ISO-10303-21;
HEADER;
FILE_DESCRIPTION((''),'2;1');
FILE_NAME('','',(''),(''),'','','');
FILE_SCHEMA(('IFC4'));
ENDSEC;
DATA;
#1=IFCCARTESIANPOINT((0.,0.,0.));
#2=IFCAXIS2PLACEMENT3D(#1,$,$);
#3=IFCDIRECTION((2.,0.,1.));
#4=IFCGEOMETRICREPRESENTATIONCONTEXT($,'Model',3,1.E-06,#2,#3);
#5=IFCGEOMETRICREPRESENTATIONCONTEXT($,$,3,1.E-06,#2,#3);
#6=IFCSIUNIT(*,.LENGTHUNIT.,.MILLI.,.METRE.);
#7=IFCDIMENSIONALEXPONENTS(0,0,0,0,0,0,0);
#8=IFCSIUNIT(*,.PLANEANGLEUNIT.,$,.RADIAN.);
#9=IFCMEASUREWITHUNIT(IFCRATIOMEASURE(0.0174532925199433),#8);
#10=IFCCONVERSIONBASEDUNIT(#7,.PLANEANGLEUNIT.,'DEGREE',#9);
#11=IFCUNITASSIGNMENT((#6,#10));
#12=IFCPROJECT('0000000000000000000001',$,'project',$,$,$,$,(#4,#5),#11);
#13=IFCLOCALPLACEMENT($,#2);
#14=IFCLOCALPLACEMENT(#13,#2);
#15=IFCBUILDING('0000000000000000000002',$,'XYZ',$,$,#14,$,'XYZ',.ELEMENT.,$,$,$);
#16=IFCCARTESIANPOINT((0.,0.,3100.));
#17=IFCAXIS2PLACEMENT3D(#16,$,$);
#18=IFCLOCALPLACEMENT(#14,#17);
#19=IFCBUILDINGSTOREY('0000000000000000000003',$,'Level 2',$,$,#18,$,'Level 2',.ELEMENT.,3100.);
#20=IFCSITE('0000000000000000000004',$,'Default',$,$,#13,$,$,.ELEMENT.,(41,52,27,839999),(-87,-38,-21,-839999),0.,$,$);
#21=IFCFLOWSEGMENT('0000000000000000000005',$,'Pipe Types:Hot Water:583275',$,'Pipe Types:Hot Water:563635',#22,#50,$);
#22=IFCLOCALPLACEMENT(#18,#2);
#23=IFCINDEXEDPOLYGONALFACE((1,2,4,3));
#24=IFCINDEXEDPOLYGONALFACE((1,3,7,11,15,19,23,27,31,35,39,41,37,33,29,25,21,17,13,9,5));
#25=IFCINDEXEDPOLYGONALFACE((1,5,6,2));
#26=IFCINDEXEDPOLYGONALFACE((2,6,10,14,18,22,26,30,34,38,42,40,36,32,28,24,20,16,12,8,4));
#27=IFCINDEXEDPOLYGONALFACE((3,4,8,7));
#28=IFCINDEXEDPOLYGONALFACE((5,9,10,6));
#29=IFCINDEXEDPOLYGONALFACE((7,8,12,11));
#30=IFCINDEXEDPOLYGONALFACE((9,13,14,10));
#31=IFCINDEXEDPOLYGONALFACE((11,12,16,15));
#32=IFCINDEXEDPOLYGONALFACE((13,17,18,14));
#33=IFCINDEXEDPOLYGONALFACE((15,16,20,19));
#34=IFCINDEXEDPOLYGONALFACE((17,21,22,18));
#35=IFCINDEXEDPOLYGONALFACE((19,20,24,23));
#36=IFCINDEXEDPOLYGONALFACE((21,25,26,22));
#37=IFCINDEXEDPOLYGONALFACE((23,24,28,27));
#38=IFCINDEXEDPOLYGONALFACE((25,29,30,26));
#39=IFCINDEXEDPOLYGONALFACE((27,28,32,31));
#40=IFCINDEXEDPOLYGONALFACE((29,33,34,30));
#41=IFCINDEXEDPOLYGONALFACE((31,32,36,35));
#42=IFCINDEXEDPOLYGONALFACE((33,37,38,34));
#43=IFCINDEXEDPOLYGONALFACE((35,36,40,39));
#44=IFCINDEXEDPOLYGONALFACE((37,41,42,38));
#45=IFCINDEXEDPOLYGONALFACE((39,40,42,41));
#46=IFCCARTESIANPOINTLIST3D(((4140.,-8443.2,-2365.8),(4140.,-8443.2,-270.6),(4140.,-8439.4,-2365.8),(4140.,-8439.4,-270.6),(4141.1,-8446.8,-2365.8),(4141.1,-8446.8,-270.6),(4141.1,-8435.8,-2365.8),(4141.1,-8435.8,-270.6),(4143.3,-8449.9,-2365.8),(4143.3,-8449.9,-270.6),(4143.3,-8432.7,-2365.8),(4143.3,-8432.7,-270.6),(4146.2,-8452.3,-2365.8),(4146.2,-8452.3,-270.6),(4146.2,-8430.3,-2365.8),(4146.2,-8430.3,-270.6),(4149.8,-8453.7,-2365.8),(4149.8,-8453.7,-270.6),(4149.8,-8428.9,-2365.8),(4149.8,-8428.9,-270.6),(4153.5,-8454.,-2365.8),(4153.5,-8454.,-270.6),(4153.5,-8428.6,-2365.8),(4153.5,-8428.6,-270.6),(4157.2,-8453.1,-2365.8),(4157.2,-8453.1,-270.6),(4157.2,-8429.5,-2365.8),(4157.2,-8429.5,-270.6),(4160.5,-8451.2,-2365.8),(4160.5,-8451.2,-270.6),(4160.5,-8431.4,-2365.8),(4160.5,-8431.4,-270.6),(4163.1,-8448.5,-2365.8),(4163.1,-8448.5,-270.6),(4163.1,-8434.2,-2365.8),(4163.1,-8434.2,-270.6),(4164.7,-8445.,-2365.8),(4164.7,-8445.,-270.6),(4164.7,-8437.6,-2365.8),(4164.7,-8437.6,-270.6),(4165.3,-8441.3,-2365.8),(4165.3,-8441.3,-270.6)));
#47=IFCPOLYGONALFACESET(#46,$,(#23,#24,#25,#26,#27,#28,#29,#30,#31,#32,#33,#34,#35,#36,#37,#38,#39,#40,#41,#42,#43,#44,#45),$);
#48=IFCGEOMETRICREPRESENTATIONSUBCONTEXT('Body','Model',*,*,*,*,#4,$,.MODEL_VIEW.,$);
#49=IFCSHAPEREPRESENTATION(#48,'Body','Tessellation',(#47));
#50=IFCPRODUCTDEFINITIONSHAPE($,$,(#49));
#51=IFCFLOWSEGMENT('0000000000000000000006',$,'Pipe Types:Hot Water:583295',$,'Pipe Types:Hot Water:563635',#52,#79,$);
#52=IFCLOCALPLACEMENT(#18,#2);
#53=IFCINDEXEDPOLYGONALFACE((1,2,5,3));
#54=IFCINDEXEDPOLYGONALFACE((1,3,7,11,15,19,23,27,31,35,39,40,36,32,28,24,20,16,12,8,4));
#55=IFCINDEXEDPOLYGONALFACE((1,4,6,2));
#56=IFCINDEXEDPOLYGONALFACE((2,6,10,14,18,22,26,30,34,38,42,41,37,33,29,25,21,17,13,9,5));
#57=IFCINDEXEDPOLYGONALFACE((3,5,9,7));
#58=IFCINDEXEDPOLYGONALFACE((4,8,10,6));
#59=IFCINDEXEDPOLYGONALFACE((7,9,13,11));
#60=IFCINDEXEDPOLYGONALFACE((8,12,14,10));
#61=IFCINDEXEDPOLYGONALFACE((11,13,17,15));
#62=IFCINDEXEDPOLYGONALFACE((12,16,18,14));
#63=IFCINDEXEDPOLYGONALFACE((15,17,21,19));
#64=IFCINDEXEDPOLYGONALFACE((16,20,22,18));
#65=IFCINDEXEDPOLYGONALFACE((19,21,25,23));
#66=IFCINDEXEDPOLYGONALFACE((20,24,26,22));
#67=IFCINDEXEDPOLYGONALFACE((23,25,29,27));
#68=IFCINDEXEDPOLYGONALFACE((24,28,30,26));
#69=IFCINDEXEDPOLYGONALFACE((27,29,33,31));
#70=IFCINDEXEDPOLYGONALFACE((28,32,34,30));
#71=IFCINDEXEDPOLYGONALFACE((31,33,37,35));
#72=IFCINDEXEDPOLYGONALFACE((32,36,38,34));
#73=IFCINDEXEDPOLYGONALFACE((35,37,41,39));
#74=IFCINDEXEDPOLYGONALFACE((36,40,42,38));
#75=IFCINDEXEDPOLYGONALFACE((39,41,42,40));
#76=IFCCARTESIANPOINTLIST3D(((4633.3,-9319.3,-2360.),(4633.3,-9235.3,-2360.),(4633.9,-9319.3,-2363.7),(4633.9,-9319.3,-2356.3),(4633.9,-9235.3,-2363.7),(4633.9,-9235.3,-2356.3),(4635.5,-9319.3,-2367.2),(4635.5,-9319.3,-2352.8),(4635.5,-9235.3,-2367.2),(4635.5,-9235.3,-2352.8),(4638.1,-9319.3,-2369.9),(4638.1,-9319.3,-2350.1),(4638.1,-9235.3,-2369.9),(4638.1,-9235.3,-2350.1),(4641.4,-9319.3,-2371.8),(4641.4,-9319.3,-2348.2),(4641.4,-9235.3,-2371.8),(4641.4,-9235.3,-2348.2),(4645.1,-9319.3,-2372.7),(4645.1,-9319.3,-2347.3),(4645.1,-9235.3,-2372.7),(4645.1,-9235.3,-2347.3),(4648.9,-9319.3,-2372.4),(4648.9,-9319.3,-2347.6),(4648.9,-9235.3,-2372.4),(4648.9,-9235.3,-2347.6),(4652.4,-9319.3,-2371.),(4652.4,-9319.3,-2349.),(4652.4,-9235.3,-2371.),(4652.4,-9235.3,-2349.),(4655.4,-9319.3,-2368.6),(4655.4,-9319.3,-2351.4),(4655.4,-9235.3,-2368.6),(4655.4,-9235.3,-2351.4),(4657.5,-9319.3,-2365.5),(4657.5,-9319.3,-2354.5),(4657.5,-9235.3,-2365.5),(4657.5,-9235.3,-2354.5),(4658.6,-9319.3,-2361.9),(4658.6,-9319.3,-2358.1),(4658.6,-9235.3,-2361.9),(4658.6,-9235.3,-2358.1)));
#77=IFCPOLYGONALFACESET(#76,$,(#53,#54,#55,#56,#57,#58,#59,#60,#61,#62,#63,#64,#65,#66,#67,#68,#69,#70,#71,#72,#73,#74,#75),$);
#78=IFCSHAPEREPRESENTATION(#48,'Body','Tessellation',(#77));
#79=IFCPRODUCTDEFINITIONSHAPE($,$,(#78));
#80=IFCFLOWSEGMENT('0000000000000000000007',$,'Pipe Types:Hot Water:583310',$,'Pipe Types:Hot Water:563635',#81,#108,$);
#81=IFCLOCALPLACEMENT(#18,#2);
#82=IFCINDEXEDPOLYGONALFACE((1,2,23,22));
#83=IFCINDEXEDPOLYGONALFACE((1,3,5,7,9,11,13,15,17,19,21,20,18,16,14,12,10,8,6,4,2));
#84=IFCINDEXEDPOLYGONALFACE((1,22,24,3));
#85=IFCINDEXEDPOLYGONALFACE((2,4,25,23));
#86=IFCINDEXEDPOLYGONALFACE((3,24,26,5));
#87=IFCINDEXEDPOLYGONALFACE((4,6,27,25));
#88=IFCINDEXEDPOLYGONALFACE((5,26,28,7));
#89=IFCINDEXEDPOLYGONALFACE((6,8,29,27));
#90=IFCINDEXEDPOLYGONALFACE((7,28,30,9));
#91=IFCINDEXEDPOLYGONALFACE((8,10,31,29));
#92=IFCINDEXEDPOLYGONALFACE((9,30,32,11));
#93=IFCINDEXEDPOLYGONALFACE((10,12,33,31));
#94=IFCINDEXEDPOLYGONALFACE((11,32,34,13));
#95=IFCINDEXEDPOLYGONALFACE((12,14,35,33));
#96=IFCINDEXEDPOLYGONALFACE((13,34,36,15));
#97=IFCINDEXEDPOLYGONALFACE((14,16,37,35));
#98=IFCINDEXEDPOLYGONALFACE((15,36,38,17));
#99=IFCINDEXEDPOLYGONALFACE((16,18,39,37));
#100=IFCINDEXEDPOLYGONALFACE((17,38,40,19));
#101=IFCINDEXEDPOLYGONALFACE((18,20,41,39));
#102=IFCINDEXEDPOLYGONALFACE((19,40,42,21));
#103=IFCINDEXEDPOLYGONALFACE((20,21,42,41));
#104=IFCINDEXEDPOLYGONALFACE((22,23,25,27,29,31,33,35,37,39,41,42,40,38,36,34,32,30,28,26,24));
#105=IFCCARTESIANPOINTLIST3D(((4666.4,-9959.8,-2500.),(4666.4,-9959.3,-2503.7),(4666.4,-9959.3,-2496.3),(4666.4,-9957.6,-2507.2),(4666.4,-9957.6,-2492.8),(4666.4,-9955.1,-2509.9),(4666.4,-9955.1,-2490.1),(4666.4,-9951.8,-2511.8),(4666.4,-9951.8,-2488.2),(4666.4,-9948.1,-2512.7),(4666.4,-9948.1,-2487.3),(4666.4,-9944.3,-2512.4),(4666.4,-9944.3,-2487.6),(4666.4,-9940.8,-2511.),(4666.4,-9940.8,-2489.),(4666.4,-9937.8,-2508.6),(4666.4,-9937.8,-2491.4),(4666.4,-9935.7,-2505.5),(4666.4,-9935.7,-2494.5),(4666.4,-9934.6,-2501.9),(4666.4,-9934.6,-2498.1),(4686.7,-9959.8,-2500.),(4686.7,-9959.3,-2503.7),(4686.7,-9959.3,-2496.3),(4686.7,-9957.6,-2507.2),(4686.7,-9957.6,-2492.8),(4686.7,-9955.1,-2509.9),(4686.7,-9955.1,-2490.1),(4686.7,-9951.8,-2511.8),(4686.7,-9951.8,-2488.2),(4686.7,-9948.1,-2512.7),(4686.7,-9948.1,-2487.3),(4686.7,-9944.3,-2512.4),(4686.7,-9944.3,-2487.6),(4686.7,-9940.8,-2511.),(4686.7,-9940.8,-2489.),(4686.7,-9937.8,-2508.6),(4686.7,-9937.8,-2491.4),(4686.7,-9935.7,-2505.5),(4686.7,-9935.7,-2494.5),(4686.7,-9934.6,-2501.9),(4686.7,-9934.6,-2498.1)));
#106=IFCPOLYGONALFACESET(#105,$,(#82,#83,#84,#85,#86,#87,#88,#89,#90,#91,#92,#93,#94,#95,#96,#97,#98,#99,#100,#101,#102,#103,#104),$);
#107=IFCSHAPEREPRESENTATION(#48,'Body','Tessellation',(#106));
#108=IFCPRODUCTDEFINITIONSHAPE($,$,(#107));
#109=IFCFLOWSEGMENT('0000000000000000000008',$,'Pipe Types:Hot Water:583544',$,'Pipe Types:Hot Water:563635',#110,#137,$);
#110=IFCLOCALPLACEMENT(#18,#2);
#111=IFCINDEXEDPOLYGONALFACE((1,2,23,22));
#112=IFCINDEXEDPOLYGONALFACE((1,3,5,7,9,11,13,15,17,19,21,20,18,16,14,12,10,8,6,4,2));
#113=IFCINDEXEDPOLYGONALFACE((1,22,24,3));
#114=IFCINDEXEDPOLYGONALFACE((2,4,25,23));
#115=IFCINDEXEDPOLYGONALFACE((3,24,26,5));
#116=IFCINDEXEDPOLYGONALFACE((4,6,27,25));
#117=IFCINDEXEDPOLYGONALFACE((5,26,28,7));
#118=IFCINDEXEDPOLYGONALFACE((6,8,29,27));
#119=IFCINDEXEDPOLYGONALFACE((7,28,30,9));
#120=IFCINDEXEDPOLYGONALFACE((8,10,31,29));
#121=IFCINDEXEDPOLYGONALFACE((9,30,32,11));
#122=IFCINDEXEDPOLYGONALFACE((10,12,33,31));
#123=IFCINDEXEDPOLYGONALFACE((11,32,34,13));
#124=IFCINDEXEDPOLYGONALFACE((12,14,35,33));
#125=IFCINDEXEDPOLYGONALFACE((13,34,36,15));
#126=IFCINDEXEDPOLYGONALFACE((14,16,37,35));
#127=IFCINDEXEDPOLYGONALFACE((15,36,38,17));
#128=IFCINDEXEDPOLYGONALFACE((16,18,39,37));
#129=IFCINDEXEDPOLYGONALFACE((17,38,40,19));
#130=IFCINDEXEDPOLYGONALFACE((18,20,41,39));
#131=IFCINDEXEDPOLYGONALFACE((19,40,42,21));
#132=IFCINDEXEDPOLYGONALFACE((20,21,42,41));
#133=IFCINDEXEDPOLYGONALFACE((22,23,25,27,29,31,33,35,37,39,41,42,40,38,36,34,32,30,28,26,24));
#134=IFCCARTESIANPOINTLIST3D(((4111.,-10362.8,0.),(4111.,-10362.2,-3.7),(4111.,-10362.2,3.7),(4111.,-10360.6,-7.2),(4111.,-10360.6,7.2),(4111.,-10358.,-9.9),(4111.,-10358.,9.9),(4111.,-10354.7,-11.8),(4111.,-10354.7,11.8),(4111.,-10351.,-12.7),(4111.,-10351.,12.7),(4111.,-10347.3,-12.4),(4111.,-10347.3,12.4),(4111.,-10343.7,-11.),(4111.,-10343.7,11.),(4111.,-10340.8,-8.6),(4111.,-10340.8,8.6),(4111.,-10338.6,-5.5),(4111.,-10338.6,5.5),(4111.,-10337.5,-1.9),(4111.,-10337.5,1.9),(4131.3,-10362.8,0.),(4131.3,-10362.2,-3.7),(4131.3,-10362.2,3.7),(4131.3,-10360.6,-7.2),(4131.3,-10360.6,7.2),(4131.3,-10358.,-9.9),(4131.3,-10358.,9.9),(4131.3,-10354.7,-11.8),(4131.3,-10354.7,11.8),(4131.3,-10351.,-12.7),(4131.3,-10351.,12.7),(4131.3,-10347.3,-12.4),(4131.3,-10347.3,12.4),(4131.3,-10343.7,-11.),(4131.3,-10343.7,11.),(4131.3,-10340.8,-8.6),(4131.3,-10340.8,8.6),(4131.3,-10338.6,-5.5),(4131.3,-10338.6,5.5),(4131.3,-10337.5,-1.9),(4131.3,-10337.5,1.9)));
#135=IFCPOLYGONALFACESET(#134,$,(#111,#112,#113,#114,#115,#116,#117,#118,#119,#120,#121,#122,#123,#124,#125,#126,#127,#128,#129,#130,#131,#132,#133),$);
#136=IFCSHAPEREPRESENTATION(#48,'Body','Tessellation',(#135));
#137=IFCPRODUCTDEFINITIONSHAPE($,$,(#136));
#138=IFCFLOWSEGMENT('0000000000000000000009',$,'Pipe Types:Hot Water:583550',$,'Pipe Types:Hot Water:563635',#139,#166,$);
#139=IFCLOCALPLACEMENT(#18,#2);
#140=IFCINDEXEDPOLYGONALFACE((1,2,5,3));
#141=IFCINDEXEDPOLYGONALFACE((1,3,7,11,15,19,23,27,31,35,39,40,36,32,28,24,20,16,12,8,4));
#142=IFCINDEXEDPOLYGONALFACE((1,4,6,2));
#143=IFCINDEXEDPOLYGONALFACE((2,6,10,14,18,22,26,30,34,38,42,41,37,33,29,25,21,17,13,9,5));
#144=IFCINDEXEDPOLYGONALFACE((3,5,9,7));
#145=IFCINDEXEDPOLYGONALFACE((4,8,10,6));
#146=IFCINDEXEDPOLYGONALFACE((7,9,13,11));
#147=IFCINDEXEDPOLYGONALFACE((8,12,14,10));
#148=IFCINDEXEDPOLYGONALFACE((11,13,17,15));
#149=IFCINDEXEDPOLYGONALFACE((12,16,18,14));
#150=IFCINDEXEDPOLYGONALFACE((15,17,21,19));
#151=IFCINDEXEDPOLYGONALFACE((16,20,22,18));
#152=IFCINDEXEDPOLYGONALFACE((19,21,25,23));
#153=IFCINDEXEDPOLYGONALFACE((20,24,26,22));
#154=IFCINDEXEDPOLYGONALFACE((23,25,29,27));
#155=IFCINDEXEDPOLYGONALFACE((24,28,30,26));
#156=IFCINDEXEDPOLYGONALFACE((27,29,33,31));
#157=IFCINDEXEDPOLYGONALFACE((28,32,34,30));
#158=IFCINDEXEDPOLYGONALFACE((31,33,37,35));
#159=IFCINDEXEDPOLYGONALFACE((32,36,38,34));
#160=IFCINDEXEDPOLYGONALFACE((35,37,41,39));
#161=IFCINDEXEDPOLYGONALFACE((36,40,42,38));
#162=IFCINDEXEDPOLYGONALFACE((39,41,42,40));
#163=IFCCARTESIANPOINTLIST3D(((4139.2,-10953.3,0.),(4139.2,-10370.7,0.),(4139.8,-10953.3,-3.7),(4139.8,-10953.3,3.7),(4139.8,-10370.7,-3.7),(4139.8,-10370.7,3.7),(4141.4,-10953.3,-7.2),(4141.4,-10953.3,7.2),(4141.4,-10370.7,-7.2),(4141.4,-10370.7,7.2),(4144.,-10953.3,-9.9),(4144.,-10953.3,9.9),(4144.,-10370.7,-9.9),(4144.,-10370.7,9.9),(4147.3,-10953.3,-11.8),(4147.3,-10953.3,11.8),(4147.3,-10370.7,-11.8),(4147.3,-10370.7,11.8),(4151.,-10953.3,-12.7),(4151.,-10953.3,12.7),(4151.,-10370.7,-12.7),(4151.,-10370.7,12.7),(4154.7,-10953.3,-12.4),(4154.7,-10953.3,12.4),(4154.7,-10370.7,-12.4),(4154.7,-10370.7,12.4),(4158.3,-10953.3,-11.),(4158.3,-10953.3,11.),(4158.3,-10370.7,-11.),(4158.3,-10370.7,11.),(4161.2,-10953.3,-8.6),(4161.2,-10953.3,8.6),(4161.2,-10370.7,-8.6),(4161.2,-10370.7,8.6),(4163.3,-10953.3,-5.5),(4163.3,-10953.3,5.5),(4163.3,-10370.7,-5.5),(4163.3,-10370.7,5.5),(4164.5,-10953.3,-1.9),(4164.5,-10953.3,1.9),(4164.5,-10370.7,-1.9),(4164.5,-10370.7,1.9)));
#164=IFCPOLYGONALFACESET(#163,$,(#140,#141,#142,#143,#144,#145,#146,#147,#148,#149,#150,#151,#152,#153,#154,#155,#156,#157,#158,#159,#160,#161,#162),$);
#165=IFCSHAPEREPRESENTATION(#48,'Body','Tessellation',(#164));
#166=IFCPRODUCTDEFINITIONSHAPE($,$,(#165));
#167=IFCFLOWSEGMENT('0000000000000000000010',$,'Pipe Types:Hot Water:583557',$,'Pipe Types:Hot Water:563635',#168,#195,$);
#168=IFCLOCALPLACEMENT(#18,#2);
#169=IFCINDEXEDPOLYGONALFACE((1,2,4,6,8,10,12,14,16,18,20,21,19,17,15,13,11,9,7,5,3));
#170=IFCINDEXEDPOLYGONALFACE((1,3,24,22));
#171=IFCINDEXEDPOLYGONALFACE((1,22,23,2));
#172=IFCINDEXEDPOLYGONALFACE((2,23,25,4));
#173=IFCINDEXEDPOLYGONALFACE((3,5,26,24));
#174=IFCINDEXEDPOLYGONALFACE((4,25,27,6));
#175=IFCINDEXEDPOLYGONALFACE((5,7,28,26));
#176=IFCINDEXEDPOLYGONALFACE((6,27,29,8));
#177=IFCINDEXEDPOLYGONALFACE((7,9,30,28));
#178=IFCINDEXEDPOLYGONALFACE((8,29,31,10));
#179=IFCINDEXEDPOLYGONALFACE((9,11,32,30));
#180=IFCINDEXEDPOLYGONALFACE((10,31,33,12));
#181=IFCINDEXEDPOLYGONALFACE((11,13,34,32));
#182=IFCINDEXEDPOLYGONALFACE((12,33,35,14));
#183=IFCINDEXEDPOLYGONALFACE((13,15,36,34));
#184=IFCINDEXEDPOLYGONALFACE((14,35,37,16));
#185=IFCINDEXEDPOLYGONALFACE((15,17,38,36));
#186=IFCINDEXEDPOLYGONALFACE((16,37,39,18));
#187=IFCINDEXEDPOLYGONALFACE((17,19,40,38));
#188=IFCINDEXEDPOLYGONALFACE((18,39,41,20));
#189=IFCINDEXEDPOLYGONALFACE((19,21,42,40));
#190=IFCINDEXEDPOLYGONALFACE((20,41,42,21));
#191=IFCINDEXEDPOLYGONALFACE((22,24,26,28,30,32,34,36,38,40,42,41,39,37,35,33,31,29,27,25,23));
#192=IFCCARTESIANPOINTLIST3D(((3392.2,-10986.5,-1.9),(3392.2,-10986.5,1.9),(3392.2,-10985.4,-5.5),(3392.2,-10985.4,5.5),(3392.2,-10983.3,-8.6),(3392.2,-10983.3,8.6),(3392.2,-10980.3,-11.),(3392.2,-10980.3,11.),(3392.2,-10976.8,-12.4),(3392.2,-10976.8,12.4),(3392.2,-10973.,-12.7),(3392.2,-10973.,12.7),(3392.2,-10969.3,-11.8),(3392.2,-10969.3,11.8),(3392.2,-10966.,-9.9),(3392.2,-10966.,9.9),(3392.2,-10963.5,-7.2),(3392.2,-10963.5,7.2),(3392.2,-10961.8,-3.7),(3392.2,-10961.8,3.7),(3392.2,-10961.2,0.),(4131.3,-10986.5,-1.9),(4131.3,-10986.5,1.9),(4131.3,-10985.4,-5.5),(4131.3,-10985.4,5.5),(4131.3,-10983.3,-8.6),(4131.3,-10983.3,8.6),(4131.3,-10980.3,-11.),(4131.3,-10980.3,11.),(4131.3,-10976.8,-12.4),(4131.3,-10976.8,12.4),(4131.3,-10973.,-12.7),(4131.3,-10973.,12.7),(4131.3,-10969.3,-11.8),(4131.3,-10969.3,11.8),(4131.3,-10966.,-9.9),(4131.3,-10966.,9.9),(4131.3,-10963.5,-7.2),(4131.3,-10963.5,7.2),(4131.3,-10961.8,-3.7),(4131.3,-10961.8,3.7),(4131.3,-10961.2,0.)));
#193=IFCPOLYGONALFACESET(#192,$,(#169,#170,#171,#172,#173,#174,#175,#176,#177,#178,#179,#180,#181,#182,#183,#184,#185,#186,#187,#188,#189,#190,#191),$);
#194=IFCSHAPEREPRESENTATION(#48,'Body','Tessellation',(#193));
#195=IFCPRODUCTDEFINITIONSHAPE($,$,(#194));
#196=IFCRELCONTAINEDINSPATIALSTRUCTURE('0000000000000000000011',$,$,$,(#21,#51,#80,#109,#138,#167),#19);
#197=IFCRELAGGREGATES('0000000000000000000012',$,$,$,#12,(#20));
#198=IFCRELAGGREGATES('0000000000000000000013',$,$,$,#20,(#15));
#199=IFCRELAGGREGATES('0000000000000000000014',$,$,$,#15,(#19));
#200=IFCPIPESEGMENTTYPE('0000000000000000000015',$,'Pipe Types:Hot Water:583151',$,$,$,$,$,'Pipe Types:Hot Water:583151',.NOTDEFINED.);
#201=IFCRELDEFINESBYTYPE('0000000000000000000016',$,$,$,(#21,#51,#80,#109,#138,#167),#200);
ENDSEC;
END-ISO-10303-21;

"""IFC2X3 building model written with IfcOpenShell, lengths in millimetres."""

from ifc_helpers import new_model, entity, si_unit, converted_unit, direction, frame, frame_2d, origin, origin_2d_with_axis, place, context, subcontext, project, spatial, circle, extrude, type_object, element, save


model = new_model("IFC2X3")

# Units and contexts
model_context = context("Model", 3, precision=1e-06, world=origin(), true_north=direction((2.0, 0.0, 1.0)))
context_of_model = context(None, 3, precision=1e-06, world=origin(), true_north=direction((2.0, 0.0, 1.0)))
body_context = subcontext(model_context, "Body", "Model", "MODEL_VIEW")
ifc_project = project(units=[si_unit("LENGTHUNIT", "METRE", prefix="MILLI"), converted_unit("PLANEANGLEUNIT", "DEGREE", entity("IfcRatioMeasure", 0.0174532925199433), si_unit("PLANEANGLEUNIT", "RADIAN"), dimensions=[0, 0, 0, 0, 0, 0, 0])], contexts=[model_context, context_of_model])

# Site, building, storey
site_placement = place(None, origin())
site = spatial("IfcSite", under=ifc_project, at=site_placement, Name="Default", CompositionType="ELEMENT", RefLatitude=(41, 52, 27, 839999), RefLongitude=(-87, -38, -21, -839999), RefElevation=0.0)
building_placement = place(site_placement, origin())
building = spatial("IfcBuilding", under=site, at=building_placement, Name="XYZ", LongName="XYZ", CompositionType="ELEMENT")
storey_placement = place(building_placement, frame((0.0, 0.0, 3100.0)))
storey = spatial("IfcBuildingStorey", under=building, at=storey_placement, Name="Level 2", LongName="Level 2", CompositionType="ELEMENT", Elevation=3100.0)

# Flow segments
pipe_segment_type_1 = type_object("IfcPipeSegmentType", Name="Pipe Types:Hot Water:583151", ElementType="Pipe Types:Hot Water:583151", PredefinedType="NOTDEFINED")
flow_segment_1_placement = place(storey_placement, origin())
element("IfcFlowSegment", 1, at=flow_segment_1_placement, inside=storey, type_object=pipe_segment_type_1, Name="Pipe Types:Hot Water:583275", ObjectType="Pipe Types:Hot Water:563635", context=body_context, shape_type="SweptSolid", body=[
    extrude(circle(Radius=12.7, at=origin_2d_with_axis()), frame((4152.6, -8441.3, -2365.8)), (0.0, 0.0, 1.0), 2095.2),
])
flow_segment_2_placement = place(storey_placement, origin())
element("IfcFlowSegment", 2, at=flow_segment_2_placement, inside=storey, type_object=pipe_segment_type_1, Name="Pipe Types:Hot Water:583295", ObjectType="Pipe Types:Hot Water:563635", context=body_context, shape_type="SweptSolid", body=[
    extrude(circle(Radius=12.7, at=frame_2d((0.0, 0.0), x_axis=(1.0, 0.0))), frame((4646.0, -9319.3, -2360.0), z_axis=(0.0, 1.0, 0.0), x_axis=(-1.0, 0.0, 0.0)), (0.0, 0.0, 1.0), 84.0),
])
flow_segment_3_placement = place(storey_placement, origin())
element("IfcFlowSegment", 3, at=flow_segment_3_placement, inside=storey, type_object=pipe_segment_type_1, Name="Pipe Types:Hot Water:583310", ObjectType="Pipe Types:Hot Water:563635", context=body_context, shape_type="SweptSolid", body=[
    extrude(circle(Radius=12.7, at=origin_2d_with_axis()), frame((4666.4, -9947.1, -2500.0), z_axis=(1.0, 0.0, 0.0), x_axis=(0.0, -1.0, 0.0)), (0.0, 0.0, 1.0), 20.3),
])
flow_segment_4_placement = place(storey_placement, origin())
element("IfcFlowSegment", 4, at=flow_segment_4_placement, inside=storey, type_object=pipe_segment_type_1, Name="Pipe Types:Hot Water:583544", ObjectType="Pipe Types:Hot Water:563635", context=body_context, shape_type="SweptSolid", body=[
    extrude(circle(Radius=12.7, at=origin_2d_with_axis()), frame((4111.0, -10350.1, 0.0), z_axis=(1.0, 0.0, 0.0), x_axis=(0.0, -1.0, 0.0)), (0.0, 0.0, 1.0), 20.3),
])
flow_segment_5_placement = place(storey_placement, origin())
element("IfcFlowSegment", 5, at=flow_segment_5_placement, inside=storey, type_object=pipe_segment_type_1, Name="Pipe Types:Hot Water:583550", ObjectType="Pipe Types:Hot Water:563635", context=body_context, shape_type="SweptSolid", body=[
    extrude(circle(Radius=12.7, at=frame_2d((0.0, 0.0), x_axis=(1.0, 0.0))), frame((4151.9, -10953.3, 0.0), z_axis=(0.0, 1.0, 0.0), x_axis=(-1.0, 0.0, 0.0)), (0.0, 0.0, 1.0), 582.6),
])
flow_segment_6_placement = place(storey_placement, origin())
element("IfcFlowSegment", 6, at=flow_segment_6_placement, inside=storey, type_object=pipe_segment_type_1, Name="Pipe Types:Hot Water:583557", ObjectType="Pipe Types:Hot Water:563635", context=body_context, shape_type="SweptSolid", body=[
    extrude(circle(Radius=12.7, at=frame_2d((0.0, 0.0), x_axis=(1.0, 0.0))), frame((3392.2, -10973.9, 0.0), z_axis=(1.0, 0.0, 0.0), x_axis=(0.0, 1.0, 0.0)), (0.0, 0.0, 1.0), 739.1),
])

save(model, "model.ifc")
